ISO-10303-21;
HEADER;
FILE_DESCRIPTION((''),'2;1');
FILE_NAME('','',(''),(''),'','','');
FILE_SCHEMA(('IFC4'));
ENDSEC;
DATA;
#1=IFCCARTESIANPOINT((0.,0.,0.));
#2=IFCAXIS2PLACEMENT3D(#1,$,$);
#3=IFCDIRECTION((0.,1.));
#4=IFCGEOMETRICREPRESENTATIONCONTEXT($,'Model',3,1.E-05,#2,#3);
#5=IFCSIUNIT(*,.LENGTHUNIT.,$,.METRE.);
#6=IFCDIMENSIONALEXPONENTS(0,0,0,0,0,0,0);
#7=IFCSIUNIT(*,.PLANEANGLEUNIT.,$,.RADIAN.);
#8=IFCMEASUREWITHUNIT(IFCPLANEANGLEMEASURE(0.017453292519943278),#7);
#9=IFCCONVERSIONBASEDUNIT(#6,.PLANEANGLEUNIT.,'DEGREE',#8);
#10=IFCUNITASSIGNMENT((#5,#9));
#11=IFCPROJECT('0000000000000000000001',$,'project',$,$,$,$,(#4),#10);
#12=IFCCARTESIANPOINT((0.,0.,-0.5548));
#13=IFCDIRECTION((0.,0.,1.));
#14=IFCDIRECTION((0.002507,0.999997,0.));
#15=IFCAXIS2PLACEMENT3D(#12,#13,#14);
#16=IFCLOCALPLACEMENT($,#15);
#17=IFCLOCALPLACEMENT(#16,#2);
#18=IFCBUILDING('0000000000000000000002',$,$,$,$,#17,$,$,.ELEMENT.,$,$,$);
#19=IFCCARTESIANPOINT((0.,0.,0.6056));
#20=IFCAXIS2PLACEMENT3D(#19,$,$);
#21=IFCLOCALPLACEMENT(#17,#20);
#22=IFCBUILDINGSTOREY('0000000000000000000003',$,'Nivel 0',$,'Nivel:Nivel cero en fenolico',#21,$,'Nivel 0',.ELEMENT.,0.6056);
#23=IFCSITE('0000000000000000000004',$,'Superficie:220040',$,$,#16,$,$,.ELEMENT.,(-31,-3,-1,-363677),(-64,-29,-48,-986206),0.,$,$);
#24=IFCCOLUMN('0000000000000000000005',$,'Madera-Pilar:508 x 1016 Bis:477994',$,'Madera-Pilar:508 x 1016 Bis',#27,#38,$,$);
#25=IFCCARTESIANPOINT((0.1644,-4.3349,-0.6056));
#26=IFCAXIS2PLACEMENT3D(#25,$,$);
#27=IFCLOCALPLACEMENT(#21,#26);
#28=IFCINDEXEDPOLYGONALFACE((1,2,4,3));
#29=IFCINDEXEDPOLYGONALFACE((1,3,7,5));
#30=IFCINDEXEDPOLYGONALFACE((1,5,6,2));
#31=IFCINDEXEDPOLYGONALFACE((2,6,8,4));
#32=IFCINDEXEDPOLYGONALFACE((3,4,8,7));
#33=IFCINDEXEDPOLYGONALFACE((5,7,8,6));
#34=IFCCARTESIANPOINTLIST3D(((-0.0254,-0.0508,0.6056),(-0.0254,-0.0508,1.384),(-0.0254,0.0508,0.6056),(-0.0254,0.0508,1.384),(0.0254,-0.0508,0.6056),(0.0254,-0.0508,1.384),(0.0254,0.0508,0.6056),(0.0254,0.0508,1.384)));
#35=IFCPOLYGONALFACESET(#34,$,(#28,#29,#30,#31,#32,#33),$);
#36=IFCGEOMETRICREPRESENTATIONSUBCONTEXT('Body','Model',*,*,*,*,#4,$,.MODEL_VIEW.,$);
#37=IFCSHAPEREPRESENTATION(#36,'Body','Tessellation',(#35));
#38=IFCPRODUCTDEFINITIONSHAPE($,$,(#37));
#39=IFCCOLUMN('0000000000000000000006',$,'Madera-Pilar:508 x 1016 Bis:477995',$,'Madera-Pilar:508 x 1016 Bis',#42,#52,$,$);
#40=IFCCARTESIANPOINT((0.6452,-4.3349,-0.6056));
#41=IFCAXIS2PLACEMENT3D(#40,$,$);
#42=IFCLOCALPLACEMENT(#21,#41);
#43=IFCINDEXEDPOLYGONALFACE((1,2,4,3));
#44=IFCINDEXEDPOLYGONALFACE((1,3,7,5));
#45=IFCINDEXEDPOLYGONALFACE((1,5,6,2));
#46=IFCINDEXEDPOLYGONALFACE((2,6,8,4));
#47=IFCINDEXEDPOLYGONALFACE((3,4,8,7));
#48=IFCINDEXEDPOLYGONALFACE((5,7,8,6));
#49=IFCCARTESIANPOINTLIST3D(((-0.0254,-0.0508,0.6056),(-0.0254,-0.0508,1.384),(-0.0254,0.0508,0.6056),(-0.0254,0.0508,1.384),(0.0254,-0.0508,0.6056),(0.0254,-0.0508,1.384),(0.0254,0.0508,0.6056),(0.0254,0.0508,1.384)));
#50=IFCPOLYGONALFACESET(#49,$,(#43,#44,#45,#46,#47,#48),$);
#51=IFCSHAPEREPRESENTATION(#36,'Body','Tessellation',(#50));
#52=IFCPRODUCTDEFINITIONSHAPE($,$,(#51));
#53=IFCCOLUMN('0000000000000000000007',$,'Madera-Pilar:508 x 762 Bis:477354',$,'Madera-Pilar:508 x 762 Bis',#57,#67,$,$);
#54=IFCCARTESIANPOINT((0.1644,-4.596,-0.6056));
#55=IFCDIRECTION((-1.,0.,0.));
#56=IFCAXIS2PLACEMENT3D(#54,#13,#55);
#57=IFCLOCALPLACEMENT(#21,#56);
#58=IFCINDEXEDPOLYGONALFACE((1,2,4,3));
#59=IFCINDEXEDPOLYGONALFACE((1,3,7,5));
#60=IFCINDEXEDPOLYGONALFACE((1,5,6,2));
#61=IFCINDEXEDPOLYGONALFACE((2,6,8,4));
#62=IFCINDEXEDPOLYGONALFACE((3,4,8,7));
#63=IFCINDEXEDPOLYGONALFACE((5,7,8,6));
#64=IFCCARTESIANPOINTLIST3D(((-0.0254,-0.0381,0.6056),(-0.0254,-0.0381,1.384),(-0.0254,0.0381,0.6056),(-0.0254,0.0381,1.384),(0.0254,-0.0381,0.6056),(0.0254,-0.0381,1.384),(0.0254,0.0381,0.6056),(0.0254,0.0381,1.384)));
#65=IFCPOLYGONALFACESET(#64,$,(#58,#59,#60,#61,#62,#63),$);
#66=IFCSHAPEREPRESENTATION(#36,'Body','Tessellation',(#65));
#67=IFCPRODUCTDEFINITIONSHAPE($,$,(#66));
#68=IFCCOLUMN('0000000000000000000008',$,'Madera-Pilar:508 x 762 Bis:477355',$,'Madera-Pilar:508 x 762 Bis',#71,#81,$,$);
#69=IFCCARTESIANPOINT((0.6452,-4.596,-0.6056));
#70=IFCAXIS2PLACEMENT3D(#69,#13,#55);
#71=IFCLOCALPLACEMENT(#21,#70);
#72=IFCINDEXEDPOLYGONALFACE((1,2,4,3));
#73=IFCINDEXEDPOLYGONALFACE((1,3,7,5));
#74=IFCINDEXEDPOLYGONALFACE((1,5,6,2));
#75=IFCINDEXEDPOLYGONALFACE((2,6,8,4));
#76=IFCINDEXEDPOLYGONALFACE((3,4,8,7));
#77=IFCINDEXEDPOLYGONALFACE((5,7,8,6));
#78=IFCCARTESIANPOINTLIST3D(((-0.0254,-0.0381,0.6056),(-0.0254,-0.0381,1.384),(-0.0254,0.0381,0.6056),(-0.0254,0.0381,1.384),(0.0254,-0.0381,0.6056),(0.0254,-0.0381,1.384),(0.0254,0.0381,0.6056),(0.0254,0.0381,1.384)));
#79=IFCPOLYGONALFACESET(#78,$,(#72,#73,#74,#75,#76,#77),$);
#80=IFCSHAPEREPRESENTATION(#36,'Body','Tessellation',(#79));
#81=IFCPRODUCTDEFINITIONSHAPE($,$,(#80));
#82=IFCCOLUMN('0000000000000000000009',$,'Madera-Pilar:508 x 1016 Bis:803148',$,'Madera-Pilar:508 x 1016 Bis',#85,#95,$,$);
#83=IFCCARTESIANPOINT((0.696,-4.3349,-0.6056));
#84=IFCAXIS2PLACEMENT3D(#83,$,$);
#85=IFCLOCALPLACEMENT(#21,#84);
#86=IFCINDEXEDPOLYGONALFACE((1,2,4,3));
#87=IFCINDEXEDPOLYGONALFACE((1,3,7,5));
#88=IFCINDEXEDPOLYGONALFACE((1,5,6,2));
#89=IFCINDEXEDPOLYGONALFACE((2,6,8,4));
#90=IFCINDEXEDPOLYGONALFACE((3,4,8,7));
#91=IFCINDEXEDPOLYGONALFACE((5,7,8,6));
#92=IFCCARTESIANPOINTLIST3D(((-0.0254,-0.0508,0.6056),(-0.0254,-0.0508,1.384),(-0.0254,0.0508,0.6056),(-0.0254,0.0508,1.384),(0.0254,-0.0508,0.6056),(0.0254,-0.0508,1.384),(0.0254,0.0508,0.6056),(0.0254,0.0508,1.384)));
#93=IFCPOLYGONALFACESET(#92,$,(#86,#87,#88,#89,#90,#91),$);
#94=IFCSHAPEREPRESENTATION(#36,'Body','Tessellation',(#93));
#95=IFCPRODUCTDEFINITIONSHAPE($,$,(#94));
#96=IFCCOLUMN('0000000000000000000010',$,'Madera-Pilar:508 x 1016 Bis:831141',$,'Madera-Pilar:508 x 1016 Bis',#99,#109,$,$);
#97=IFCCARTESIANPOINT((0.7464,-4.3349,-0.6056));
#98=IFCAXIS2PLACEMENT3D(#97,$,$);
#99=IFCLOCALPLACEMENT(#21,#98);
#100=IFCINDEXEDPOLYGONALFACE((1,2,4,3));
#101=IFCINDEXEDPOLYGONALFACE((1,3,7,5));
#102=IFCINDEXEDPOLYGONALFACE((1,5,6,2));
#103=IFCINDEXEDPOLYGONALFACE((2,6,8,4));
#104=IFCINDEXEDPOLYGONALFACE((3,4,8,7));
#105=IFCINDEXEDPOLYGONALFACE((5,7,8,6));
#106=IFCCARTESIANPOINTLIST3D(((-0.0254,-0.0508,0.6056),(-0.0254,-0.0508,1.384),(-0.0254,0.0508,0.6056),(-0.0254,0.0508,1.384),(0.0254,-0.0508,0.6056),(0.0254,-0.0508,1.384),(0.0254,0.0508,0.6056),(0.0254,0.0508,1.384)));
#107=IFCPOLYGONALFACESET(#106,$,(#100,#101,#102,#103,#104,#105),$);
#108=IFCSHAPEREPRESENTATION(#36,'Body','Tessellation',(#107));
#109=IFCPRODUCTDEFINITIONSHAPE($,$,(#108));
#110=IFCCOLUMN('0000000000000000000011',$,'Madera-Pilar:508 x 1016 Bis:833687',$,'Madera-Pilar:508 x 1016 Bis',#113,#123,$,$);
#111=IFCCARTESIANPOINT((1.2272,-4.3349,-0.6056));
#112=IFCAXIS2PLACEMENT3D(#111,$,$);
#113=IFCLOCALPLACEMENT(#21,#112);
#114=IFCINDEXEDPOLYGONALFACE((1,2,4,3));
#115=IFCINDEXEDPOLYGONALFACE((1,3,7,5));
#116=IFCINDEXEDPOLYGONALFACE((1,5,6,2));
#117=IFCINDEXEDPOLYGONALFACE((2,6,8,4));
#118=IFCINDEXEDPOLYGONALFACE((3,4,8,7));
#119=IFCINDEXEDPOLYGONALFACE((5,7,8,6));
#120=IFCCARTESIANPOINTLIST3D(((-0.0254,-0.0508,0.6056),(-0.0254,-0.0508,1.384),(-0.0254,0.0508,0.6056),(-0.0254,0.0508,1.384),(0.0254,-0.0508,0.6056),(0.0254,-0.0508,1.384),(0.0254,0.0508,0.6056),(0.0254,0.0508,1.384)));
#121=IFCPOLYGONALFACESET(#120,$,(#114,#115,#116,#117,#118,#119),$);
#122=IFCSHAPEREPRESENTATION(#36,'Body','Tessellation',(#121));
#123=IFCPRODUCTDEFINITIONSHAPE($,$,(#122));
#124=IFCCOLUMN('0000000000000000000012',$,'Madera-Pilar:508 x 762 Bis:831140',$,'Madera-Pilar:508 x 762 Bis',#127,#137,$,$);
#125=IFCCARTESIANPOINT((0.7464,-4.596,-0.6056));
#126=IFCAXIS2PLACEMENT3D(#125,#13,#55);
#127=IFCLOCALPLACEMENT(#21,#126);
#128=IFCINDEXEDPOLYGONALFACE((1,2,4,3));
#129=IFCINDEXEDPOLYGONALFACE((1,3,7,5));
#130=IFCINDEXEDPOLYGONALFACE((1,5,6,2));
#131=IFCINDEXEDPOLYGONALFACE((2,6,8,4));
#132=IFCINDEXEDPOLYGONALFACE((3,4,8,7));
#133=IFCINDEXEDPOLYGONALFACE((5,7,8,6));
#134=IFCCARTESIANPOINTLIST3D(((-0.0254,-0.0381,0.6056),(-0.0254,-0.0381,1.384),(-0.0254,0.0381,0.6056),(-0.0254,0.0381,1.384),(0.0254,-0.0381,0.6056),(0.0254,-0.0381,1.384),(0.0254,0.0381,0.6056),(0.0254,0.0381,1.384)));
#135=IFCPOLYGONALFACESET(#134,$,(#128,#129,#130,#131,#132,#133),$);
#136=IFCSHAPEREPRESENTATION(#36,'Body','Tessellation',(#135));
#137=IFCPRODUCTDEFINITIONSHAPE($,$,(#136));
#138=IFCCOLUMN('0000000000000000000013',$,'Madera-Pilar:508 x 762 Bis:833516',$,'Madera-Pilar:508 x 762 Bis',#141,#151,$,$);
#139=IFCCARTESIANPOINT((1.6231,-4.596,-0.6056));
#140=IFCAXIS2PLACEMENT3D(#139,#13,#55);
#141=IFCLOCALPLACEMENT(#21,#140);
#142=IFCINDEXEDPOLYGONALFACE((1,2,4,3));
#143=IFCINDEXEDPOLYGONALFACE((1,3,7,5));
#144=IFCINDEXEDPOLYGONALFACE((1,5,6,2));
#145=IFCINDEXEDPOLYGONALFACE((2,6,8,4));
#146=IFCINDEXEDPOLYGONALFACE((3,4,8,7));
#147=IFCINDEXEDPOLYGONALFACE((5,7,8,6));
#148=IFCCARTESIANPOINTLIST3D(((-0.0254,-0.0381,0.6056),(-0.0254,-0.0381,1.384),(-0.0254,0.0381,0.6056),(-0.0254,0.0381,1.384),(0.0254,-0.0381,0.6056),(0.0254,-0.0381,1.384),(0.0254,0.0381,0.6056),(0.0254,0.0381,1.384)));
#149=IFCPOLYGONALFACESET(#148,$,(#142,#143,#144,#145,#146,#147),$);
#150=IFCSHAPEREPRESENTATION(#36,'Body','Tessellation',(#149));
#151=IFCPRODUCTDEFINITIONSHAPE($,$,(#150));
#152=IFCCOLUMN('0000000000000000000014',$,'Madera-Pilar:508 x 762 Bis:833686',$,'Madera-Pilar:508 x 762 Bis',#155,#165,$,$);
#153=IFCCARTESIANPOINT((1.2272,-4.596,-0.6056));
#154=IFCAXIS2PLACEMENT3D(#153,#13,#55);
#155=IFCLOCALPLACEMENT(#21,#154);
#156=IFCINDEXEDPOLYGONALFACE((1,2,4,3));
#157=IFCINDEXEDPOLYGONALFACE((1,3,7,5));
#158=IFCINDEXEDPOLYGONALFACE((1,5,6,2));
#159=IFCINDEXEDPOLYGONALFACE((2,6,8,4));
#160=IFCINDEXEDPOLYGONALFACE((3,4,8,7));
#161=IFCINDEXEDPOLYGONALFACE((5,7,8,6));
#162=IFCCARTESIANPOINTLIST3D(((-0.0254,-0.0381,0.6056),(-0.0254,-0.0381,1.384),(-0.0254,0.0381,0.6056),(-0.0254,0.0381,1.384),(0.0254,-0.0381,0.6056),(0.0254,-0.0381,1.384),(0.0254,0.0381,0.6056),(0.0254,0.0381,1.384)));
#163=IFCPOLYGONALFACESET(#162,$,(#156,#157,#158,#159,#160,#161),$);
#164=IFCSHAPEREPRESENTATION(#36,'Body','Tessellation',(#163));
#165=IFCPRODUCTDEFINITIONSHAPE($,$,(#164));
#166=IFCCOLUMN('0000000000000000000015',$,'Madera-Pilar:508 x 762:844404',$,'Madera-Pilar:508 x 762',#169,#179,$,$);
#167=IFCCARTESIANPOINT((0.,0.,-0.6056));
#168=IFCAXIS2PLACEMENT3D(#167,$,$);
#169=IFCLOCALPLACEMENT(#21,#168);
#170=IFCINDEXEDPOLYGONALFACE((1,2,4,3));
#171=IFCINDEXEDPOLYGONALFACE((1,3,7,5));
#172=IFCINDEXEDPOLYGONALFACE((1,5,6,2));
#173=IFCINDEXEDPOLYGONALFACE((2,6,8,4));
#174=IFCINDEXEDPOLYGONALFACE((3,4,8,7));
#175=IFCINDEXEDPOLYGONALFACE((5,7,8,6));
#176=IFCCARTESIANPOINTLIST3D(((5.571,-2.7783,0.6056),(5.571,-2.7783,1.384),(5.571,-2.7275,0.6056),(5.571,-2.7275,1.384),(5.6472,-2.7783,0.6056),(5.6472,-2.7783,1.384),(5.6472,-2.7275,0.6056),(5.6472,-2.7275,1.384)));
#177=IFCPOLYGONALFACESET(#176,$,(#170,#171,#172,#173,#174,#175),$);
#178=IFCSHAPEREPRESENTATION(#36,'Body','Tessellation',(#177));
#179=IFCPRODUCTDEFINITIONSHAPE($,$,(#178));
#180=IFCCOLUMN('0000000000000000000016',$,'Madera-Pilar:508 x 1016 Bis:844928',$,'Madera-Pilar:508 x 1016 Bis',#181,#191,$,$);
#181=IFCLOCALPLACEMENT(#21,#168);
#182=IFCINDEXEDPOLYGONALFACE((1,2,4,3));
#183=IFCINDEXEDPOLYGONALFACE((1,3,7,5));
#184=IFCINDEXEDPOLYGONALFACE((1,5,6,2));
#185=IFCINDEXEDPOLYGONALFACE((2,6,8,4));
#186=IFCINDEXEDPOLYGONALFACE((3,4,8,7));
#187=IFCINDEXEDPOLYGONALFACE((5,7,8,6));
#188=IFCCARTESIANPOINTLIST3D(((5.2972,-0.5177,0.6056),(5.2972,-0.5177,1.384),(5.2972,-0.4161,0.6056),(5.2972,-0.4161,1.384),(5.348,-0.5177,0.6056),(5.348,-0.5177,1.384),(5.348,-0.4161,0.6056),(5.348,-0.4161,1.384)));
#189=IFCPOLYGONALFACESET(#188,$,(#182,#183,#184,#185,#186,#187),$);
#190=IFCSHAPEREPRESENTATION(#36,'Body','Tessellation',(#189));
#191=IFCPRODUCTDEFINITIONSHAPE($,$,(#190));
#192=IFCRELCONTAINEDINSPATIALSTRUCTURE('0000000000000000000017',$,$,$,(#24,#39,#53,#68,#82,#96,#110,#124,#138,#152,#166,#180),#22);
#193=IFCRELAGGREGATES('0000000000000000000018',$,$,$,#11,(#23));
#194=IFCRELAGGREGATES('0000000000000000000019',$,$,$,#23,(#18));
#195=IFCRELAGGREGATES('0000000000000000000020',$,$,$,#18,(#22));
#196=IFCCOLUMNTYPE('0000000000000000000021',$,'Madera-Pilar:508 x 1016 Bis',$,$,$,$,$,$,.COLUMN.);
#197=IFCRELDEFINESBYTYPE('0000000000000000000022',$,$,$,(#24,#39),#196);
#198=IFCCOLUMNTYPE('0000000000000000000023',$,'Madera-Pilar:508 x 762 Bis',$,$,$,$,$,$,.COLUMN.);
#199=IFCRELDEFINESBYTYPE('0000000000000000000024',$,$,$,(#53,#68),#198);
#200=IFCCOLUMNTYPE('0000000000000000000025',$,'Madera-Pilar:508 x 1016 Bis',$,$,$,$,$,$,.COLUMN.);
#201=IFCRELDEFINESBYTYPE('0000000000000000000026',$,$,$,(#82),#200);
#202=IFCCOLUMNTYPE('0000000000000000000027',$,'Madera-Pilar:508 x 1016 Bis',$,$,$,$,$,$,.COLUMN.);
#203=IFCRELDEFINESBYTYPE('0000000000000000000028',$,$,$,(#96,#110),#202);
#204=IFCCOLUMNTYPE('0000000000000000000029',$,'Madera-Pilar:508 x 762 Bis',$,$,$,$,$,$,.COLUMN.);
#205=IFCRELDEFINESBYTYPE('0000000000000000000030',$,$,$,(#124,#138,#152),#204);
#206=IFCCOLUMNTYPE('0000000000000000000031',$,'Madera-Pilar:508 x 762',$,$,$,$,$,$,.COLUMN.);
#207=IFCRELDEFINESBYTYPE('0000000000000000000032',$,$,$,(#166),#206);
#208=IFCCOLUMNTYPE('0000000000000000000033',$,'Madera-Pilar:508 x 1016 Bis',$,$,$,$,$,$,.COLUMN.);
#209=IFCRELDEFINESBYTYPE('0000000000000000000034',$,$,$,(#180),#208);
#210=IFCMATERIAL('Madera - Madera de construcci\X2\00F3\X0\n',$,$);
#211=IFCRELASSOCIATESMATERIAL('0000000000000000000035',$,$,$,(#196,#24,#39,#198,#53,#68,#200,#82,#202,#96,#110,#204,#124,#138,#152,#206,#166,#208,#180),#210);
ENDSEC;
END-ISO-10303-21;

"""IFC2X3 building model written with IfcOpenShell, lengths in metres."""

from ifc_helpers import new_model, entity, si_unit, converted_unit, direction, frame, frame_2d, origin, origin_2d_with_axis, place, context, subcontext, project, spatial, rectangle, extrude, source, transform, mapped, material, type_object, type_shapes, element, save


model = new_model("IFC2X3")

# Units and contexts
model_context = context("Model", 3, precision=1e-05, world=origin(), true_north=direction((0.0, 1.0)))
body_context = subcontext(model_context, "Body", "Model", "MODEL_VIEW")
ifc_project = project(units=[si_unit("LENGTHUNIT", "METRE"), converted_unit("PLANEANGLEUNIT", "DEGREE", entity("IfcPlaneAngleMeasure", 0.017453292519943278), si_unit("PLANEANGLEUNIT", "RADIAN"), dimensions=[0, 0, 0, 0, 0, 0, 0])], contexts=[model_context])

# Site, building, storey
site_placement = place(None, frame((0.0, 0.0, -0.5548), z_axis=(0.0, 0.0, 1.0), x_axis=(0.002507, 0.999997, 0.0)))
site = spatial("IfcSite", under=ifc_project, at=site_placement, Name="Superficie:220040", CompositionType="ELEMENT", RefLatitude=(-31, -3, -1, -363677), RefLongitude=(-64, -29, -48, -986206), RefElevation=0.0)
building_placement = place(site_placement, origin())
building = spatial("IfcBuilding", under=site, at=building_placement, CompositionType="ELEMENT")
storey_placement = place(building_placement, frame((0.0, 0.0, 0.6056)))
storey = spatial("IfcBuildingStorey", under=building, at=storey_placement, Name="Nivel 0", ObjectType="Nivel:Nivel cero en fenolico", LongName="Nivel 0", CompositionType="ELEMENT", Elevation=0.6056)

# Columns
ifc_material = material(Name="Madera - Madera de construcción")
column_type_1 = type_object("IfcColumnType", Name="Madera-Pilar:508 x 1016 Bis", PredefinedType="COLUMN", material=ifc_material)
shared_shape_1 = source(origin(), body_context, "Body", "SweptSolid", [
    extrude(rectangle(XDim=0.0508, YDim=0.1016, at=origin_2d_with_axis()), frame((0.0, 0.0, 0.6056), z_axis=(0.0, 0.0, 1.0), x_axis=(-1.0, 0.0, 0.0)), (0.0, 0.0, 1.0), 0.7784),
])
type_shapes(column_type_1, [shared_shape_1])
for number, where, name in (
    (1, (0.1644, -4.3349, -0.6056), "Madera-Pilar:508 x 1016 Bis:477994"),
    (2, (0.6452, -4.3349, -0.6056), "Madera-Pilar:508 x 1016 Bis:477995"),
):
    element("IfcColumn", number, at=place(storey_placement, frame(where)), inside=storey, type_object=column_type_1, material=ifc_material, Name=name, ObjectType="Madera-Pilar:508 x 1016 Bis", context=body_context, shape_type="MappedRepresentation", body=[
        mapped(shared_shape_1, transform((0.0, 0.0, 0.0), scale=1.0)),
    ])
column_type_2 = type_object("IfcColumnType", Name="Madera-Pilar:508 x 762 Bis", PredefinedType="COLUMN", material=ifc_material)
shared_shape_2 = source(origin(), body_context, "Body", "SweptSolid", [
    extrude(rectangle(XDim=0.0508, YDim=0.0762, at=origin_2d_with_axis()), frame((0.0, 0.0, 0.6056), z_axis=(0.0, 0.0, 1.0), x_axis=(-1.0, 0.0, 0.0)), (0.0, 0.0, 1.0), 0.7784),
])
type_shapes(column_type_2, [shared_shape_2])
for number, where, z_axis, x_axis, name in (
    (3, (0.1644, -4.596, -0.6056), (0.0, 0.0, 1.0), (-1.0, 0.0, 0.0), "Madera-Pilar:508 x 762 Bis:477354"),
    (4, (0.6452, -4.596, -0.6056), (0.0, 0.0, 1.0), (-1.0, 0.0, 0.0), "Madera-Pilar:508 x 762 Bis:477355"),
):
    element("IfcColumn", number, at=place(storey_placement, frame(where, z_axis=z_axis, x_axis=x_axis)), inside=storey, type_object=column_type_2, material=ifc_material, Name=name, ObjectType="Madera-Pilar:508 x 762 Bis", context=body_context, shape_type="MappedRepresentation", body=[
        mapped(shared_shape_2, transform((0.0, 0.0, 0.0), scale=1.0)),
    ])
column_type_3 = type_object("IfcColumnType", Name="Madera-Pilar:508 x 1016 Bis", PredefinedType="COLUMN", material=ifc_material)
shared_shape_3 = source(origin(), body_context, "Body", "SweptSolid", [
    extrude(rectangle(XDim=0.0508, YDim=0.1016, at=origin_2d_with_axis()), frame((0.0, 0.0, 0.6056), z_axis=(0.0, 0.0, 1.0), x_axis=(-1.0, 0.0, 0.0)), (0.0, 0.0, 1.0), 0.7784),
])
type_shapes(column_type_3, [shared_shape_3])
column_1_placement = place(storey_placement, frame((0.696, -4.3349, -0.6056)))
element("IfcColumn", 5, at=column_1_placement, inside=storey, type_object=column_type_3, material=ifc_material, Name="Madera-Pilar:508 x 1016 Bis:803148", ObjectType="Madera-Pilar:508 x 1016 Bis", context=body_context, shape_type="MappedRepresentation", body=[
    mapped(shared_shape_3, transform((0.0, 0.0, 0.0), scale=1.0)),
])
column_type_4 = type_object("IfcColumnType", Name="Madera-Pilar:508 x 1016 Bis", PredefinedType="COLUMN", material=ifc_material)
shared_shape_4 = source(origin(), body_context, "Body", "SweptSolid", [
    extrude(rectangle(XDim=0.0508, YDim=0.1016, at=origin_2d_with_axis()), frame((0.0, 0.0, 0.6056), z_axis=(0.0, 0.0, 1.0), x_axis=(-1.0, 0.0, 0.0)), (0.0, 0.0, 1.0), 0.7784),
])
type_shapes(column_type_4, [shared_shape_4])
for number, where, name in (
    (6, (0.7464, -4.3349, -0.6056), "Madera-Pilar:508 x 1016 Bis:831141"),
    (7, (1.2272, -4.3349, -0.6056), "Madera-Pilar:508 x 1016 Bis:833687"),
):
    element("IfcColumn", number, at=place(storey_placement, frame(where)), inside=storey, type_object=column_type_4, material=ifc_material, Name=name, ObjectType="Madera-Pilar:508 x 1016 Bis", context=body_context, shape_type="MappedRepresentation", body=[
        mapped(shared_shape_4, transform((0.0, 0.0, 0.0), scale=1.0)),
    ])
column_type_5 = type_object("IfcColumnType", Name="Madera-Pilar:508 x 762 Bis", PredefinedType="COLUMN", material=ifc_material)
shared_shape_5 = source(origin(), body_context, "Body", "SweptSolid", [
    extrude(rectangle(XDim=0.0508, YDim=0.0762, at=origin_2d_with_axis()), frame((0.0, 0.0, 0.6056), z_axis=(0.0, 0.0, 1.0), x_axis=(-1.0, 0.0, 0.0)), (0.0, 0.0, 1.0), 0.7784),
])
type_shapes(column_type_5, [shared_shape_5])
for number, where, z_axis, x_axis, name in (
    (8, (0.7464, -4.596, -0.6056), (0.0, 0.0, 1.0), (-1.0, 0.0, 0.0), "Madera-Pilar:508 x 762 Bis:831140"),
    (9, (1.6231, -4.596, -0.6056), (0.0, 0.0, 1.0), (-1.0, 0.0, 0.0), "Madera-Pilar:508 x 762 Bis:833516"),
    (10, (1.2272, -4.596, -0.6056), (0.0, 0.0, 1.0), (-1.0, 0.0, 0.0), "Madera-Pilar:508 x 762 Bis:833686"),
):
    element("IfcColumn", number, at=place(storey_placement, frame(where, z_axis=z_axis, x_axis=x_axis)), inside=storey, type_object=column_type_5, material=ifc_material, Name=name, ObjectType="Madera-Pilar:508 x 762 Bis", context=body_context, shape_type="MappedRepresentation", body=[
        mapped(shared_shape_5, transform((0.0, 0.0, 0.0), scale=1.0)),
    ])
column_type_6 = type_object("IfcColumnType", Name="Madera-Pilar:508 x 762", PredefinedType="COLUMN", material=ifc_material)
shared_shape_6 = source(origin(), body_context, "Body", "SweptSolid", [
    extrude(rectangle(XDim=0.0762, YDim=0.0508, at=frame_2d((0.0, 0.0), x_axis=(1.0, 0.0))), frame((5.6091, -2.7529, 0.6056), z_axis=(0.0, 0.0, 1.0), x_axis=(-1.0, 0.0, 0.0)), (0.0, 0.0, 1.0), 0.7784),
])
type_shapes(column_type_6, [shared_shape_6])
column_2_placement = place(storey_placement, frame((0.0, 0.0, -0.6056)))
element("IfcColumn", 11, at=column_2_placement, inside=storey, type_object=column_type_6, material=ifc_material, Name="Madera-Pilar:508 x 762:844404", ObjectType="Madera-Pilar:508 x 762", context=body_context, shape_type="MappedRepresentation", body=[
    mapped(shared_shape_6, transform((0.0, 0.0, 0.0), scale=1.0)),
])
column_type_7 = type_object("IfcColumnType", Name="Madera-Pilar:508 x 1016 Bis", PredefinedType="COLUMN", material=ifc_material)
shared_shape_7 = source(origin(), body_context, "Body", "SweptSolid", [
    extrude(rectangle(XDim=0.0508, YDim=0.1016, at=frame_2d((0.0, 0.0), x_axis=(1.0, 0.0))), frame((5.3226, -0.4669, 0.6056)), (0.0, 0.0, 1.0), 0.7784),
])
type_shapes(column_type_7, [shared_shape_7])
column_3_placement = place(storey_placement, frame((0.0, 0.0, -0.6056)))
element("IfcColumn", 12, at=column_3_placement, inside=storey, type_object=column_type_7, material=ifc_material, Name="Madera-Pilar:508 x 1016 Bis:844928", ObjectType="Madera-Pilar:508 x 1016 Bis", context=body_context, shape_type="MappedRepresentation", body=[
    mapped(shared_shape_7, transform((0.0, 0.0, 0.0), scale=1.0)),
])

save(model, "model.ifc")
